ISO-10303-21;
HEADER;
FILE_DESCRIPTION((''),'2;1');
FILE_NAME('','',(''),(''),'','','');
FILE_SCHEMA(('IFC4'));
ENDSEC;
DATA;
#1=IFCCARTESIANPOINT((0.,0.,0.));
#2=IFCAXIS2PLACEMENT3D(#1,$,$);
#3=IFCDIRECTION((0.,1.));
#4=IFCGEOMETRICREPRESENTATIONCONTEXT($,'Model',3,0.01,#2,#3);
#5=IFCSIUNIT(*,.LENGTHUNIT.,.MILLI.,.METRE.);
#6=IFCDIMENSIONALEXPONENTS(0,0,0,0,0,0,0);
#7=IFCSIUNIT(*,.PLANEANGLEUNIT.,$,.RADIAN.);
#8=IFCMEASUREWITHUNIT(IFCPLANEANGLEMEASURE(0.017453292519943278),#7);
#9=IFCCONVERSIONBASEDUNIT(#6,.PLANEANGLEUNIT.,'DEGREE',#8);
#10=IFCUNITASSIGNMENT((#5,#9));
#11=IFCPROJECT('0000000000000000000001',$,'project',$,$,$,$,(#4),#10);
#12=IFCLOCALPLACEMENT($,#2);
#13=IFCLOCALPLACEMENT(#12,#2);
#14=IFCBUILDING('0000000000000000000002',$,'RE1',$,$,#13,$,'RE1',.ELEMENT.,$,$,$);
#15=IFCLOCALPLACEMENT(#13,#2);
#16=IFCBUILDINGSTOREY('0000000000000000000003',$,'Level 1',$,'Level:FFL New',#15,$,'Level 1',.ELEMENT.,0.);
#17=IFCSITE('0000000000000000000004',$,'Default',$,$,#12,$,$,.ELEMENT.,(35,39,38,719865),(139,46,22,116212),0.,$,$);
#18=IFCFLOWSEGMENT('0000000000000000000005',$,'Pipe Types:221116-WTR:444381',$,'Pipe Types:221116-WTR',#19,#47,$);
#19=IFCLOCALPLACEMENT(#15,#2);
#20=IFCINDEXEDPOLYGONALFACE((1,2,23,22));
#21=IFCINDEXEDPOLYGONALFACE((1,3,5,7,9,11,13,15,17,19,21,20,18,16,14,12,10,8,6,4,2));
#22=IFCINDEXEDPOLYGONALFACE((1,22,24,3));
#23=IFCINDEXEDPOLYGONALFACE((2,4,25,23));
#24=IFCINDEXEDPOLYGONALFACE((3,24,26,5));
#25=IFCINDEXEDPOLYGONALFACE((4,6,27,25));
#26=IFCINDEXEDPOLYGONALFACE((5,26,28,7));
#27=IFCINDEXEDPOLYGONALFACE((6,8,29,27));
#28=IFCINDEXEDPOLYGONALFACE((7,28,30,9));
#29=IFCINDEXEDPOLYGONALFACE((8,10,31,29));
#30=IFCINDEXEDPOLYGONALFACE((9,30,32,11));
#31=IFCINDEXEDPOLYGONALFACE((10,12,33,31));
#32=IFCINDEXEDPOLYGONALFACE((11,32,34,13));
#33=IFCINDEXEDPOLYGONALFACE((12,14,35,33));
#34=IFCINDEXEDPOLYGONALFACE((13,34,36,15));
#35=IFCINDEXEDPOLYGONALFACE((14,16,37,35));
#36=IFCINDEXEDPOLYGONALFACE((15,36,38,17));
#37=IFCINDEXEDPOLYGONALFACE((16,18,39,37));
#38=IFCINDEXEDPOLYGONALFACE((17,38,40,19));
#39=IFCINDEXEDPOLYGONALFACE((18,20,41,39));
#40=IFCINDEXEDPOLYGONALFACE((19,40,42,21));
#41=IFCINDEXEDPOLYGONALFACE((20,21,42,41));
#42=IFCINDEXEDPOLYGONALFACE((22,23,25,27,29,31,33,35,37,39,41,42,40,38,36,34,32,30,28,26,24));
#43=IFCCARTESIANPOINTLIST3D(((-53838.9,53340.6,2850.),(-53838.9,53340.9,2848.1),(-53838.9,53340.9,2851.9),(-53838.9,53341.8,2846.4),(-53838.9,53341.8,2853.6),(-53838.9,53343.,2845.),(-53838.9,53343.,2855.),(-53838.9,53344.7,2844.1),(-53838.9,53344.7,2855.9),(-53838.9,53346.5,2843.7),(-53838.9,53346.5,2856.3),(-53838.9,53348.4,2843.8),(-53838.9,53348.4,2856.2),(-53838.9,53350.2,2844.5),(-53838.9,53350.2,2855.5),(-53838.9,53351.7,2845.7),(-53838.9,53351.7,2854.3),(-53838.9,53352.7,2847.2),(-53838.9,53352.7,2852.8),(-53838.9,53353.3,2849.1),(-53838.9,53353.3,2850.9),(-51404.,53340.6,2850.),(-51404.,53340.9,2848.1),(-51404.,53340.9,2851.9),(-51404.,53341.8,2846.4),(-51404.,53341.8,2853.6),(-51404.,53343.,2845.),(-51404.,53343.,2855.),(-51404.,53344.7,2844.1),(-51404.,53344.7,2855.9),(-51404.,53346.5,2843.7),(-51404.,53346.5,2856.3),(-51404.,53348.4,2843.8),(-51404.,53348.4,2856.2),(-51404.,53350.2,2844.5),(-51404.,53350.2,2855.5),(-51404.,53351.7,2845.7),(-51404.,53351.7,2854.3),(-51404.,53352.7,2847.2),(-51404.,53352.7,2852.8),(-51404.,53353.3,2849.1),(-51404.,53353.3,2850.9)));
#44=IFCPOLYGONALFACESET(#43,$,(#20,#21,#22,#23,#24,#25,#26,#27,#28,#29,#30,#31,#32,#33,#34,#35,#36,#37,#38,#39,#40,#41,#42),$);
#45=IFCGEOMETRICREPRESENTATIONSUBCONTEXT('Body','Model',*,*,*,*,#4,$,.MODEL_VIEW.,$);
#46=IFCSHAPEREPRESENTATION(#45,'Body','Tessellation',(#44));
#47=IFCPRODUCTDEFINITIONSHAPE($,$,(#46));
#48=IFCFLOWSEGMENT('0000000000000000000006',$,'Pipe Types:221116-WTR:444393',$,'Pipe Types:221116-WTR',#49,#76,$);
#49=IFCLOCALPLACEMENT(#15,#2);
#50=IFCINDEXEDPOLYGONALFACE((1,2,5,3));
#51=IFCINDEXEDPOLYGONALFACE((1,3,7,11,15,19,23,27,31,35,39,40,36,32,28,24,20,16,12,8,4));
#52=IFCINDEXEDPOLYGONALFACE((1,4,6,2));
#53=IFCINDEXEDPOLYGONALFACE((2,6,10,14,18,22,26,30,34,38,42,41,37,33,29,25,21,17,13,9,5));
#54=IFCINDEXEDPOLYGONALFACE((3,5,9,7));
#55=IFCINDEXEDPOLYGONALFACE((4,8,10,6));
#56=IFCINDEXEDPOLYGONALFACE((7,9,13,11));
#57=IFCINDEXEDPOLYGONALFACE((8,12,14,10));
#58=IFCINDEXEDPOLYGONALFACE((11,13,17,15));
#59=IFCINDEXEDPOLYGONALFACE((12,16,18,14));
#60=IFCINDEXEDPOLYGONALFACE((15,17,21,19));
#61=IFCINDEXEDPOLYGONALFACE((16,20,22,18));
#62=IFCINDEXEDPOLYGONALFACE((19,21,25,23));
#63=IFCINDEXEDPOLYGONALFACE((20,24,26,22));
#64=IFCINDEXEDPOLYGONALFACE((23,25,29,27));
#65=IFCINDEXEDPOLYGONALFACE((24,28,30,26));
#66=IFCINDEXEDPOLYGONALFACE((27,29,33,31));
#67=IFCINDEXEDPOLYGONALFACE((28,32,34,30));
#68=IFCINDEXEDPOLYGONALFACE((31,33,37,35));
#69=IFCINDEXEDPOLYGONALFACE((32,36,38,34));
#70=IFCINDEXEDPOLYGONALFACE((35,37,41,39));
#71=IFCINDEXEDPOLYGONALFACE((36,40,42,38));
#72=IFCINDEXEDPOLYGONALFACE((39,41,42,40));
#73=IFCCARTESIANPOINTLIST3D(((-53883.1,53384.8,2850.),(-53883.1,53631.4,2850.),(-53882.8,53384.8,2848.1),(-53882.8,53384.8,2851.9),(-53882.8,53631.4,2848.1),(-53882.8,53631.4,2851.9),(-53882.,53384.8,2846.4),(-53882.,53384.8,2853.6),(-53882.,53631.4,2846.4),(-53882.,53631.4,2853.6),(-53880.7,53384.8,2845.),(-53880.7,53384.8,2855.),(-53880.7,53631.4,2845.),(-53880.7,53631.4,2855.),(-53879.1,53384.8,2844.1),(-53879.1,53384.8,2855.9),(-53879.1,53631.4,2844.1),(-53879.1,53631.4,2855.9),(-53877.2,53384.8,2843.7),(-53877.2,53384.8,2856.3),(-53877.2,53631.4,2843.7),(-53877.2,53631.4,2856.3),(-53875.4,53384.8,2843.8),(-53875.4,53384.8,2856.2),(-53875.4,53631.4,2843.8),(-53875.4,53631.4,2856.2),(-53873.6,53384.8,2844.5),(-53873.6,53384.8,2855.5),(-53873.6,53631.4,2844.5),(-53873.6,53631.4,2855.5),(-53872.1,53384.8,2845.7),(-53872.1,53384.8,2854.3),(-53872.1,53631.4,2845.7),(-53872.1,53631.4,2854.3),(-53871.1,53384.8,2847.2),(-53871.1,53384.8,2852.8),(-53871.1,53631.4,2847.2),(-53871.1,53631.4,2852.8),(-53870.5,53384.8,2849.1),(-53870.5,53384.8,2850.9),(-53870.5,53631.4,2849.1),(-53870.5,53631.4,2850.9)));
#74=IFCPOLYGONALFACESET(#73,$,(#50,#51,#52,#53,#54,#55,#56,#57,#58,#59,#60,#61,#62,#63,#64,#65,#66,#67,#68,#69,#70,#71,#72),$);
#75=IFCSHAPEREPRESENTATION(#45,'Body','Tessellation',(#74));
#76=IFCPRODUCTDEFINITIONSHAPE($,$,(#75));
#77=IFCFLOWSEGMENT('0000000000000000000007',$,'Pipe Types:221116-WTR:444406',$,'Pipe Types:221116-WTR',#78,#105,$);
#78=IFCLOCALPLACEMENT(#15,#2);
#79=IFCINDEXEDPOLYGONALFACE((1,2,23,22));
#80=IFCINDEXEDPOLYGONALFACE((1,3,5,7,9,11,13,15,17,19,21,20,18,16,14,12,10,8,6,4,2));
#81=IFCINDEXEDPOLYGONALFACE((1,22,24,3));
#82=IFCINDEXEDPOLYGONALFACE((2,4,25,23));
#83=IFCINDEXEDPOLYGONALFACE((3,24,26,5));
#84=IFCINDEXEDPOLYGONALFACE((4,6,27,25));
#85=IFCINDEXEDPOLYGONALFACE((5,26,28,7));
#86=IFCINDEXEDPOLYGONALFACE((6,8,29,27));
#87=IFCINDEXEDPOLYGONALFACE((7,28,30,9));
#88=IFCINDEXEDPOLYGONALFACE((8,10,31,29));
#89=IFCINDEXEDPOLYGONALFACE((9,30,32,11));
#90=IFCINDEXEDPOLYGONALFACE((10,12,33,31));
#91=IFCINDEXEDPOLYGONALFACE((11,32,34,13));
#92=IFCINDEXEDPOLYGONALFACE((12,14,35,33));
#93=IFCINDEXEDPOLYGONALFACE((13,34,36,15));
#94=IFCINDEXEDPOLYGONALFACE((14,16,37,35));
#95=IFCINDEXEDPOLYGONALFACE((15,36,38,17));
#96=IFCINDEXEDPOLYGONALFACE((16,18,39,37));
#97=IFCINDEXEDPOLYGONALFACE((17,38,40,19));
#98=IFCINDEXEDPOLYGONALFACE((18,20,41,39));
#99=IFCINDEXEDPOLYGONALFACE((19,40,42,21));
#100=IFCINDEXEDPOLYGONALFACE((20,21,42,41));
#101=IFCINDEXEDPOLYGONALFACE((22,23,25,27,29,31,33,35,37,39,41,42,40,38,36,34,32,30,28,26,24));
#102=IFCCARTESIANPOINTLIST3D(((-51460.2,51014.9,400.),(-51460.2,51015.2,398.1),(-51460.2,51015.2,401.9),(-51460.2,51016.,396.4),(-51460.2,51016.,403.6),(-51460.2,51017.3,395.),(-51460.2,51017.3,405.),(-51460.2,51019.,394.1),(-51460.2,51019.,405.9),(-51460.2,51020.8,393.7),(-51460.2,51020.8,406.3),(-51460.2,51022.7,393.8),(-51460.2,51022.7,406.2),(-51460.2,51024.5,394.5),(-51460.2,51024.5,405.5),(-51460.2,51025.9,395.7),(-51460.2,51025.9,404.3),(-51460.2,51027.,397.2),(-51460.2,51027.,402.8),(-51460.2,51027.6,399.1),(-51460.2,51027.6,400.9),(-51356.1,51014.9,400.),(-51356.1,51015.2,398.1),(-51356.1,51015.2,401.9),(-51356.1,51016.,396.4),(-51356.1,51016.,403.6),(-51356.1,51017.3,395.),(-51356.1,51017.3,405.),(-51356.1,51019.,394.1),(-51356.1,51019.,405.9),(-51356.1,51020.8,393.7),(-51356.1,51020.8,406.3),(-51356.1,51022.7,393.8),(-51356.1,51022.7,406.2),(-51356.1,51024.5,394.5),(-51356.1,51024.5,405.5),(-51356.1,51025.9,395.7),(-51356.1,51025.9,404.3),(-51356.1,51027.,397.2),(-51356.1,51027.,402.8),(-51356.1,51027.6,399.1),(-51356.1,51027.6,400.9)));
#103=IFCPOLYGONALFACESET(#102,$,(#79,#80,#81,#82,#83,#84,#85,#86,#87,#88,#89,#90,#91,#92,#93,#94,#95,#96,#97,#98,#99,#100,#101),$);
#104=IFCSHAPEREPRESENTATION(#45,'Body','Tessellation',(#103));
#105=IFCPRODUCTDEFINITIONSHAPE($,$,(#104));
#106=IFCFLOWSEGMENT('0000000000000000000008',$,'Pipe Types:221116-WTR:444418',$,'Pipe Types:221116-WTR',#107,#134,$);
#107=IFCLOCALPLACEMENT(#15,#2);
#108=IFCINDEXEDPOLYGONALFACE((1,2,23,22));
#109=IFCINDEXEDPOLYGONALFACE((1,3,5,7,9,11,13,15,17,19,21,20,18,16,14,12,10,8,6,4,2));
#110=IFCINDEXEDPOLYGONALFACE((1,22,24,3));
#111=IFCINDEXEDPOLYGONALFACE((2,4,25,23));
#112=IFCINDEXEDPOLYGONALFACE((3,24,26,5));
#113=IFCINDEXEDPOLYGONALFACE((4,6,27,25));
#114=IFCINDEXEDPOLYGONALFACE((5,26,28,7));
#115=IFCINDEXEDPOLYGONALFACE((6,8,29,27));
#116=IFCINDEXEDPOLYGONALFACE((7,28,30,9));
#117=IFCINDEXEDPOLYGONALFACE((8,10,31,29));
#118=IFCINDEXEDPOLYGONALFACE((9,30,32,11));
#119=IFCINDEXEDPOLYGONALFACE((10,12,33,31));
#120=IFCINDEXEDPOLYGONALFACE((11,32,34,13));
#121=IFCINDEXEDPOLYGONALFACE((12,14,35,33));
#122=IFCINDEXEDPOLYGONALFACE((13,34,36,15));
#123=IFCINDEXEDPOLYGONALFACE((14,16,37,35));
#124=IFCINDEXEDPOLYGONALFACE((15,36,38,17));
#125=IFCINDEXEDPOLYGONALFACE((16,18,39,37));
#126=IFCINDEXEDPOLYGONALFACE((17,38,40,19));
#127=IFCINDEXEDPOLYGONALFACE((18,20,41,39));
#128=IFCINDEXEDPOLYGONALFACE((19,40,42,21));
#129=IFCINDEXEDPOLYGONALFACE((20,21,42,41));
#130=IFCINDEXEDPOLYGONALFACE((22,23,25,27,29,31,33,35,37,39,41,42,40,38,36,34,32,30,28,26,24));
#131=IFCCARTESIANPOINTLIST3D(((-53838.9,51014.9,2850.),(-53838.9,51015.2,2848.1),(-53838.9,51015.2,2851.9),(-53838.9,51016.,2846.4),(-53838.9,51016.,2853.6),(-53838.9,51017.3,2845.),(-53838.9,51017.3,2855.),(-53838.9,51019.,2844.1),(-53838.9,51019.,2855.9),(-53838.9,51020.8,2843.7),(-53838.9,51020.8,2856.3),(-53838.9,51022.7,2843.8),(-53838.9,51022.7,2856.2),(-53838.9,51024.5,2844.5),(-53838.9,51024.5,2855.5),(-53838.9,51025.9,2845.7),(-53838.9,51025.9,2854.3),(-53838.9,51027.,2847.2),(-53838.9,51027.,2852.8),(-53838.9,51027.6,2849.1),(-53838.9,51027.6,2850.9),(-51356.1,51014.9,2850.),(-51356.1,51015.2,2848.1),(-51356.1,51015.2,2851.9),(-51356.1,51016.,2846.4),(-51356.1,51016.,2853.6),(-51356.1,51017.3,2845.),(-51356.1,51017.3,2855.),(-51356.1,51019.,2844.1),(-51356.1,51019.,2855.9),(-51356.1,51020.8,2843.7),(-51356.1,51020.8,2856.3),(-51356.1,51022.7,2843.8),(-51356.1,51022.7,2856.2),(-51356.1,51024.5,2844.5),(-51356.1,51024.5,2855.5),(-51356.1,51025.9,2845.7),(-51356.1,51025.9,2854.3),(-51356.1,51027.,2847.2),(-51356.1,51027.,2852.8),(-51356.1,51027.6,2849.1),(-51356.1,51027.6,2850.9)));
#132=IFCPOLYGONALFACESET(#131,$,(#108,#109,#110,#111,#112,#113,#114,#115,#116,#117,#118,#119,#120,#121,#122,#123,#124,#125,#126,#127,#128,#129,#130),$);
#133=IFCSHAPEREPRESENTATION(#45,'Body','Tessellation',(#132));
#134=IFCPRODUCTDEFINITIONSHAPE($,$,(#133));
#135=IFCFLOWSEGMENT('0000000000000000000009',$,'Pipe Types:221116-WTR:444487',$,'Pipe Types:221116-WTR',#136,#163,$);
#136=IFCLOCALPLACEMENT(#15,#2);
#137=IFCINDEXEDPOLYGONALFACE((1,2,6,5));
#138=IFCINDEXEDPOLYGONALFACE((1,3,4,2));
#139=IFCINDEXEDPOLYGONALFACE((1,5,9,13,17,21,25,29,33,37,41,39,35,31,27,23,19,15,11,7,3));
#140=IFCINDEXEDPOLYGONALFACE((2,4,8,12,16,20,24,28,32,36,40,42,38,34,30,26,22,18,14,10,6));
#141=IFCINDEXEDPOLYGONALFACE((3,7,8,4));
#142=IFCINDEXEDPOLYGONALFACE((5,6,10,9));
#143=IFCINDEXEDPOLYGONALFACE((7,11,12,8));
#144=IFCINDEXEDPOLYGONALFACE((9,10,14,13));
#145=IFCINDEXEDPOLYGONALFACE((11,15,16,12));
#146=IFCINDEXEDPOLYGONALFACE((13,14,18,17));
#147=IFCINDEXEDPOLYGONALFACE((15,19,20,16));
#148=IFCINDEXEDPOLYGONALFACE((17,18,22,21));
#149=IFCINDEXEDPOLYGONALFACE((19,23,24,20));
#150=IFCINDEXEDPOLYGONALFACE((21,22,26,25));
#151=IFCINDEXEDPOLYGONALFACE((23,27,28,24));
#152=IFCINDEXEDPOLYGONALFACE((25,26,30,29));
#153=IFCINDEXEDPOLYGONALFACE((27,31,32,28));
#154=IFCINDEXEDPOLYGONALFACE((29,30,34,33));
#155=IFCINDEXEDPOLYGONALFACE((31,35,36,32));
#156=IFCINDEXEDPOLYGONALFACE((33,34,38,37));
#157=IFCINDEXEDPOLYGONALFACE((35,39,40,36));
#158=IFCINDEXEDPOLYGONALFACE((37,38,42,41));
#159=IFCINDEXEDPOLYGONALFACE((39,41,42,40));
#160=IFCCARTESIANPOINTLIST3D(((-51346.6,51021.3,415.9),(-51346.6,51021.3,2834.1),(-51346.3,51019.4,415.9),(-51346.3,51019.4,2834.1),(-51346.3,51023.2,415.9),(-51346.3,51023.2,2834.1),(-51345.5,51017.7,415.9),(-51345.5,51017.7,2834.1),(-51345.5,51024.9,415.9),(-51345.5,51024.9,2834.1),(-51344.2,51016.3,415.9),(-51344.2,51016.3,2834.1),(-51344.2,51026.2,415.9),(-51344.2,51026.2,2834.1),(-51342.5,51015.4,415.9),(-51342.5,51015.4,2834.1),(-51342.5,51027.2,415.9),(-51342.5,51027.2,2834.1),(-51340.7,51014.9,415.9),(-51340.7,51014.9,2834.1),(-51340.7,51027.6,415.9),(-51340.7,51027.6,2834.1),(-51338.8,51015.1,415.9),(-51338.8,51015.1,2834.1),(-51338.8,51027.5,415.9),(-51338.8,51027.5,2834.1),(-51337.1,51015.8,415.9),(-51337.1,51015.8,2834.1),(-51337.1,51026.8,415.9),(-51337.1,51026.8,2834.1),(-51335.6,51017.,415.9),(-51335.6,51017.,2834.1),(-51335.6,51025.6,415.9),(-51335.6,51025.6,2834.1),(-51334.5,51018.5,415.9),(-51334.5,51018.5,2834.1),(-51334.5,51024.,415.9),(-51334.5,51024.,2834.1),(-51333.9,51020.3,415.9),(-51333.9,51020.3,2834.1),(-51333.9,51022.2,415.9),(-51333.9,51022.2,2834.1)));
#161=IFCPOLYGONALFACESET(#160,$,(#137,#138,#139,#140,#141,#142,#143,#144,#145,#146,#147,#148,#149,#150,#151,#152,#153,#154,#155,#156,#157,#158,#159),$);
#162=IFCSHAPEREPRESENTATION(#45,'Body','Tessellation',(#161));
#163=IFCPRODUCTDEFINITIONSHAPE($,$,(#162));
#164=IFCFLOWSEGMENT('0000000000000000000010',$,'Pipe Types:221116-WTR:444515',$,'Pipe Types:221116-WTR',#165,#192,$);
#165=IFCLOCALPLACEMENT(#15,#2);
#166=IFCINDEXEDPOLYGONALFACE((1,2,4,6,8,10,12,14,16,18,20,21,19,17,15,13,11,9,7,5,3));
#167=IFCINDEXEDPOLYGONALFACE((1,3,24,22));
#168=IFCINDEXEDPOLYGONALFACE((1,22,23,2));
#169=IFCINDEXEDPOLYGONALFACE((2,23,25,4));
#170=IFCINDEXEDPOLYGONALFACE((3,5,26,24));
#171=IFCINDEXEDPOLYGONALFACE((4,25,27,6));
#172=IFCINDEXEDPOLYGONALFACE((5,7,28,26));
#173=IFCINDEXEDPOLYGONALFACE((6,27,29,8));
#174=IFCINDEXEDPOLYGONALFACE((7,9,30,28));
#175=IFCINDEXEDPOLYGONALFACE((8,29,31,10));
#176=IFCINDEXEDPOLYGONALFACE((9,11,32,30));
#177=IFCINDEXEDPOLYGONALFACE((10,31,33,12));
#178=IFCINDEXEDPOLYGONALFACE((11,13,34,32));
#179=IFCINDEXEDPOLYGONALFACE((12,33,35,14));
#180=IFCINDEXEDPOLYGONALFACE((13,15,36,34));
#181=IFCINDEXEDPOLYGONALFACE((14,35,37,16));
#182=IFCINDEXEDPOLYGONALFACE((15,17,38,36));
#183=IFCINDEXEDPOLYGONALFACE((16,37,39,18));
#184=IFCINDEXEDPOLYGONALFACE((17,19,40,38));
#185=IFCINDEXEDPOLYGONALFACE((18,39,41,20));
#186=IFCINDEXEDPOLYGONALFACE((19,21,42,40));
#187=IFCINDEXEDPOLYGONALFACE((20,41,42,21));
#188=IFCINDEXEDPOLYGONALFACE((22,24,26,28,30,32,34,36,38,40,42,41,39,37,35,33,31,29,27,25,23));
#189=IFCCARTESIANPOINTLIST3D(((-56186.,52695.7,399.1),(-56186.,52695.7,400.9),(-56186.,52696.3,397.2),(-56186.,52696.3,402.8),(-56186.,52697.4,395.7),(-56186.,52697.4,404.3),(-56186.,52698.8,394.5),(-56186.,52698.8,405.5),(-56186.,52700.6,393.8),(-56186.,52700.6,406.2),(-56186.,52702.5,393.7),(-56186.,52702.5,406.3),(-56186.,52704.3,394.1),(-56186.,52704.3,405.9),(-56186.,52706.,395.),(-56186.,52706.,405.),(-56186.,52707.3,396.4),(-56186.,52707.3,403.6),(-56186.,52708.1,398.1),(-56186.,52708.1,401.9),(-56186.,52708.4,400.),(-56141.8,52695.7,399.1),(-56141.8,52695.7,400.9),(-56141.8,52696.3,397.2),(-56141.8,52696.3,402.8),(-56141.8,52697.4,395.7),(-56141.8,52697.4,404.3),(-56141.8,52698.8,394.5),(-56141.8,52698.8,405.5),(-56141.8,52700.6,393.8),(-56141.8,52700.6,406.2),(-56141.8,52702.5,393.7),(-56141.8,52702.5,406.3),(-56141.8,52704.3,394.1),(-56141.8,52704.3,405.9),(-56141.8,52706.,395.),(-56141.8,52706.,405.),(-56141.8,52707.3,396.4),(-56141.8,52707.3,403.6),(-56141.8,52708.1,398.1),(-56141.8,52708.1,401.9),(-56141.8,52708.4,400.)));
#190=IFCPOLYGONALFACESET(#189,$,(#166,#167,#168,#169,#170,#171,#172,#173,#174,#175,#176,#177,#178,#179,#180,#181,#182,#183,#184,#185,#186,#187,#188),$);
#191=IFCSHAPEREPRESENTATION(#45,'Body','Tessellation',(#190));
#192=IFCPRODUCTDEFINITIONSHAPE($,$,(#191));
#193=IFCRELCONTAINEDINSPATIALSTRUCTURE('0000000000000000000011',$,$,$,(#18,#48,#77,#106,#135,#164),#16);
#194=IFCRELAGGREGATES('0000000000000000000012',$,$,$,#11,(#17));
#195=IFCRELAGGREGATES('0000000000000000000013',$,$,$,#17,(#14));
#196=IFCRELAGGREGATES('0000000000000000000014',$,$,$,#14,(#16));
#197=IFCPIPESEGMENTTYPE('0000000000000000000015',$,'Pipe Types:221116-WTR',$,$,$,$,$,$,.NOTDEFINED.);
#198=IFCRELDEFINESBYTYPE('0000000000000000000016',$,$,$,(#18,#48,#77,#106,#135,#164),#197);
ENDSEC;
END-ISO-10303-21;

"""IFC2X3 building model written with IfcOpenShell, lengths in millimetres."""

from ifc_helpers import new_model, entity, si_unit, converted_unit, direction, frame, frame_2d, origin, origin_2d_with_axis, place, context, subcontext, project, spatial, circle, extrude, type_object, element, save


model = new_model("IFC2X3")

# Units and contexts
model_context = context("Model", 3, precision=0.01, world=origin(), true_north=direction((0.0, 1.0)))
body_context = subcontext(model_context, "Body", "Model", "MODEL_VIEW")
ifc_project = project(units=[si_unit("LENGTHUNIT", "METRE", prefix="MILLI"), converted_unit("PLANEANGLEUNIT", "DEGREE", entity("IfcPlaneAngleMeasure", 0.017453292519943278), si_unit("PLANEANGLEUNIT", "RADIAN"), dimensions=[0, 0, 0, 0, 0, 0, 0])], contexts=[model_context])

# Site, building, storey
site_placement = place(None, origin())
site = spatial("IfcSite", under=ifc_project, at=site_placement, Name="Default", CompositionType="ELEMENT", RefLatitude=(35, 39, 38, 719865), RefLongitude=(139, 46, 22, 116212), RefElevation=0.0)
building_placement = place(site_placement, origin())
building = spatial("IfcBuilding", under=site, at=building_placement, Name="RE1", LongName="RE1", CompositionType="ELEMENT")
storey_placement = place(building_placement, origin())
storey = spatial("IfcBuildingStorey", under=building, at=storey_placement, Name="Level 1", ObjectType="Level:FFL New", LongName="Level 1", CompositionType="ELEMENT", Elevation=0.0)

# Flow segments
pipe_segment_type_1 = type_object("IfcPipeSegmentType", Name="Pipe Types:221116-WTR", PredefinedType="NOTDEFINED")
flow_segment_1_placement = place(storey_placement, origin())
element("IfcFlowSegment", 1, at=flow_segment_1_placement, inside=storey, type_object=pipe_segment_type_1, Name="Pipe Types:221116-WTR:444381", ObjectType="Pipe Types:221116-WTR", context=body_context, shape_type="SweptSolid", body=[
    extrude(circle(Radius=6.3, at=origin_2d_with_axis()), frame((-53838.9, 53347.0, 2850.0), z_axis=(1.0, 0.0, 0.0), x_axis=(0.0, -1.0, 0.0)), (0.0, 0.0, 1.0), 2434.9),
])
flow_segment_2_placement = place(storey_placement, origin())
element("IfcFlowSegment", 2, at=flow_segment_2_placement, inside=storey, type_object=pipe_segment_type_1, Name="Pipe Types:221116-WTR:444393", ObjectType="Pipe Types:221116-WTR", context=body_context, shape_type="SweptSolid", body=[
    extrude(circle(Radius=6.3, at=origin_2d_with_axis()), frame((-53876.8, 53384.8, 2850.0), z_axis=(0.0, 1.0, 0.0), x_axis=(-1.0, 0.0, 0.0)), (0.0, 0.0, 1.0), 246.6),
])
flow_segment_3_placement = place(storey_placement, origin())
element("IfcFlowSegment", 3, at=flow_segment_3_placement, inside=storey, type_object=pipe_segment_type_1, Name="Pipe Types:221116-WTR:444406", ObjectType="Pipe Types:221116-WTR", context=body_context, shape_type="SweptSolid", body=[
    extrude(circle(Radius=6.3, at=frame_2d((0.0, 0.0), x_axis=(1.0, 0.0))), frame((-51460.2, 51021.3, 400.0), z_axis=(1.0, 0.0, 0.0), x_axis=(0.0, -1.0, 0.0)), (0.0, 0.0, 1.0), 104.1),
])
flow_segment_4_placement = place(storey_placement, origin())
element("IfcFlowSegment", 4, at=flow_segment_4_placement, inside=storey, type_object=pipe_segment_type_1, Name="Pipe Types:221116-WTR:444418", ObjectType="Pipe Types:221116-WTR", context=body_context, shape_type="SweptSolid", body=[
    extrude(circle(Radius=6.3, at=origin_2d_with_axis()), frame((-53838.9, 51021.3, 2850.0), z_axis=(1.0, 0.0, 0.0), x_axis=(0.0, -1.0, 0.0)), (0.0, 0.0, 1.0), 2482.8),
])
flow_segment_5_placement = place(storey_placement, origin())
element("IfcFlowSegment", 5, at=flow_segment_5_placement, inside=storey, type_object=pipe_segment_type_1, Name="Pipe Types:221116-WTR:444487", ObjectType="Pipe Types:221116-WTR", context=body_context, shape_type="SweptSolid", body=[
    extrude(circle(Radius=6.3, at=origin_2d_with_axis()), frame((-51340.2, 51021.3, 415.9), z_axis=(0.0, 0.0, 1.0), x_axis=(-1.0, 0.0, 0.0)), (0.0, 0.0, 1.0), 2418.2),
])
flow_segment_6_placement = place(storey_placement, origin())
element("IfcFlowSegment", 6, at=flow_segment_6_placement, inside=storey, type_object=pipe_segment_type_1, Name="Pipe Types:221116-WTR:444515", ObjectType="Pipe Types:221116-WTR", context=body_context, shape_type="SweptSolid", body=[
    extrude(circle(Radius=6.3, at=frame_2d((0.0, 0.0), x_axis=(1.0, 0.0))), frame((-56186.0, 52702.0, 400.0), z_axis=(1.0, 0.0, 0.0), x_axis=(0.0, 1.0, 0.0)), (0.0, 0.0, 1.0), 44.1),
])

save(model, "model.ifc")
